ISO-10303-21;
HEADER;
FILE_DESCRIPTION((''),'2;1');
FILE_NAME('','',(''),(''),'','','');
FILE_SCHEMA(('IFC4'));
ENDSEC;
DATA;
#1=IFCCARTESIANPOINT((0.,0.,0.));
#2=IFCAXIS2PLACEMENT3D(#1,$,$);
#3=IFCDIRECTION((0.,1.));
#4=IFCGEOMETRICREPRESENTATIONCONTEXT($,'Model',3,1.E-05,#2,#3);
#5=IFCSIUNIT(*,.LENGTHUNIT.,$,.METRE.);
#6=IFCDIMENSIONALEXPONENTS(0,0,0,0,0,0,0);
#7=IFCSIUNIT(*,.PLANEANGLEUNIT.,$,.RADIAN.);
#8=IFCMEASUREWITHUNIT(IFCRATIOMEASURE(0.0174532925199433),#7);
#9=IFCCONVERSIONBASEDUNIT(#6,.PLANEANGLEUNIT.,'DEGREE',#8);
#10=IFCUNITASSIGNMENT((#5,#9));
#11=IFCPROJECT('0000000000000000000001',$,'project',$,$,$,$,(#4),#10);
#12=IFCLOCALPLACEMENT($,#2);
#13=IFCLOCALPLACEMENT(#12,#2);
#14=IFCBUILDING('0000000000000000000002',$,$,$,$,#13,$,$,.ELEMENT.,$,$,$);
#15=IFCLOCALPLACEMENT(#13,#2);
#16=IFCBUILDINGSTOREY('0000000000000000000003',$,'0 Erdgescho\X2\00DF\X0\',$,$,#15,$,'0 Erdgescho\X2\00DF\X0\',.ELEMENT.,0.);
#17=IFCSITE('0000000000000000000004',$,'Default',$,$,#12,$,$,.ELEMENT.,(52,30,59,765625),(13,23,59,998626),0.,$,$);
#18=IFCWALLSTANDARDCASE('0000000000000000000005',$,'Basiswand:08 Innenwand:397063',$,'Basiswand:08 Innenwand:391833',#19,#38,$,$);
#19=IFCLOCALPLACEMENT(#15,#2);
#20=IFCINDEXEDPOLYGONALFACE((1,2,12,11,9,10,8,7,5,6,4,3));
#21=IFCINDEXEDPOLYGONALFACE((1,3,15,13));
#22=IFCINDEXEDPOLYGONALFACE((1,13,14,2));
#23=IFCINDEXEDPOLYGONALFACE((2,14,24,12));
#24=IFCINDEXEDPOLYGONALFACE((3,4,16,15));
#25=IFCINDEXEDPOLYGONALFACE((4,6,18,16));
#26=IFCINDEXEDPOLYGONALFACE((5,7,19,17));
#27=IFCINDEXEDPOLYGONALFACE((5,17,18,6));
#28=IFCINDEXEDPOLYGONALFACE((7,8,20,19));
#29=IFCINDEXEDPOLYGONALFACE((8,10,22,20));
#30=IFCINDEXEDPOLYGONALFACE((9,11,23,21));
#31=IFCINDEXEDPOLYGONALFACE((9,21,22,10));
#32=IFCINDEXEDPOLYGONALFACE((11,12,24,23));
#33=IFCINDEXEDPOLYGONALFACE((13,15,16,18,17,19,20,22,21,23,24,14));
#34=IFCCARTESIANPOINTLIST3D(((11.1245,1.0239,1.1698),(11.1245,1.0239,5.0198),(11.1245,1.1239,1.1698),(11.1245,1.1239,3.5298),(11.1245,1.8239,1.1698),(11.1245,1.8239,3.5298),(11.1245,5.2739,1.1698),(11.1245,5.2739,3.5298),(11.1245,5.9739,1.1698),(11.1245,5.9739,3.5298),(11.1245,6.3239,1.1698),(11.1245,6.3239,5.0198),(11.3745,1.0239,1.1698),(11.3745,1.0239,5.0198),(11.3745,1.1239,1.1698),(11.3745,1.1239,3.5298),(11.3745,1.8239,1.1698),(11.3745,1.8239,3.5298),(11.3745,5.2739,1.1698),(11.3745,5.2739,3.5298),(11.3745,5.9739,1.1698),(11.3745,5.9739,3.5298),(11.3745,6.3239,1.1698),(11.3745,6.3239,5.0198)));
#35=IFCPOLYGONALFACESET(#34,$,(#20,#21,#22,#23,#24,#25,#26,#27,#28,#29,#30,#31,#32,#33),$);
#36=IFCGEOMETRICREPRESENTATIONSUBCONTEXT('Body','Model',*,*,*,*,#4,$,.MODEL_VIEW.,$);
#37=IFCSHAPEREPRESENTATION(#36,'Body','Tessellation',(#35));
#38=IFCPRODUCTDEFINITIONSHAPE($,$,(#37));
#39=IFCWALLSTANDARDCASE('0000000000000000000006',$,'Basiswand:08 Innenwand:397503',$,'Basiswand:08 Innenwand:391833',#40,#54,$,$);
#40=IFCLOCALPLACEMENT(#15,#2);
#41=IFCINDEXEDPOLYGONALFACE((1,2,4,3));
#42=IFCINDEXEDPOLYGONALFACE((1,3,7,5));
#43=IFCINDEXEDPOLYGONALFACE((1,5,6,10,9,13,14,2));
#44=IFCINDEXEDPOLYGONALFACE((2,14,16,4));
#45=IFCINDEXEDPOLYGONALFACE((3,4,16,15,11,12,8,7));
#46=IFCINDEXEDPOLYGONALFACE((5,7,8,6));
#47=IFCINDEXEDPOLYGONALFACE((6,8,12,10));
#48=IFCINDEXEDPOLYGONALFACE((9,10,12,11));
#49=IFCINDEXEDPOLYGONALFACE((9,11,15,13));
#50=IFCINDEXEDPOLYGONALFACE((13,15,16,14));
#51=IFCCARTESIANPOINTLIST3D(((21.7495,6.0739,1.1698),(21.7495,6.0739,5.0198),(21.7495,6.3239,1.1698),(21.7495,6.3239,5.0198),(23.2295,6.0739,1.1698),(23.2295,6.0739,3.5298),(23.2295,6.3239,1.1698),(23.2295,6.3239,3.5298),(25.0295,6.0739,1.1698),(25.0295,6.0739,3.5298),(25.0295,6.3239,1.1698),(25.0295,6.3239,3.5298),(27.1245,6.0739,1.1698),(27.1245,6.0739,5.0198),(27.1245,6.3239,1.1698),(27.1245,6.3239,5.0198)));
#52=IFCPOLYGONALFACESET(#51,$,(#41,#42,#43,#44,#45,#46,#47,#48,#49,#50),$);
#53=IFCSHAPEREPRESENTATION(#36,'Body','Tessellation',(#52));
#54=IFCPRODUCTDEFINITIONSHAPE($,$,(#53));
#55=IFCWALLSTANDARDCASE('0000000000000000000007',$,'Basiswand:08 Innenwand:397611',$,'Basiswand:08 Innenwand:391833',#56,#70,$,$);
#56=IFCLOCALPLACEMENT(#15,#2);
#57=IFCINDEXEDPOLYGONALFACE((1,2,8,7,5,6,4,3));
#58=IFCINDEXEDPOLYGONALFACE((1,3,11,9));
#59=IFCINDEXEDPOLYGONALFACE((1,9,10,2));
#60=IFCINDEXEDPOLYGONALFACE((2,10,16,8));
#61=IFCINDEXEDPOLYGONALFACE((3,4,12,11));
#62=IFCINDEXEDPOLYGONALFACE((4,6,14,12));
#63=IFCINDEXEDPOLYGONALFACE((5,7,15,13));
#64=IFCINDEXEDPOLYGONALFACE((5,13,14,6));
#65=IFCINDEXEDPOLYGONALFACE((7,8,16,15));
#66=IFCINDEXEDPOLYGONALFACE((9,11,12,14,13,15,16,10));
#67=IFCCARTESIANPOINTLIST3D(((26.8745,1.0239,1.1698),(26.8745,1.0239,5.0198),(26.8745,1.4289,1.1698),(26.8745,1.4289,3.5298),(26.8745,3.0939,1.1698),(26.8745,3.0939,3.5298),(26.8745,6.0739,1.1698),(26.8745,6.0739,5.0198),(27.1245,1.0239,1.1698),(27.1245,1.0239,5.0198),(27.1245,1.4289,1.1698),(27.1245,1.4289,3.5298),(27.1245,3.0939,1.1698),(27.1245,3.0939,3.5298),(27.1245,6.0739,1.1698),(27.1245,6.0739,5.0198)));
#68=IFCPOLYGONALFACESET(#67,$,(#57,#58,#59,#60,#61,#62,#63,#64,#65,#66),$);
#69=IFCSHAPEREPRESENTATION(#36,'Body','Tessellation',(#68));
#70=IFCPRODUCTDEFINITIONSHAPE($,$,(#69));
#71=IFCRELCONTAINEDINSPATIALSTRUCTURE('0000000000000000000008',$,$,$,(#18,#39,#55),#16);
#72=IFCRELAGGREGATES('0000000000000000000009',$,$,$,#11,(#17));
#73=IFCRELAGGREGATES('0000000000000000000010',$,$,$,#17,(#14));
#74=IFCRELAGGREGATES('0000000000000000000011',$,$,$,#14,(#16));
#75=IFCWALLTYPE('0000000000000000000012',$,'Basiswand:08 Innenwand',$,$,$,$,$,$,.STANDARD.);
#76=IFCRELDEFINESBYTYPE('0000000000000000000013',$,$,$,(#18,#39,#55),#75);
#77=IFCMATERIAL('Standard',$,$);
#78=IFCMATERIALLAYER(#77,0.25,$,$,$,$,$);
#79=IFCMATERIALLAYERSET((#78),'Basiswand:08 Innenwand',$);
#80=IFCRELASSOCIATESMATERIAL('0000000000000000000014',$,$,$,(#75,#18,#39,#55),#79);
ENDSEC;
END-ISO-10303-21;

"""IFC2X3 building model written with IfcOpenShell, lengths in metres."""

from ifc_helpers import new_model, entity, si_unit, converted_unit, direction, frame, frame_2d, origin, place, context, subcontext, project, spatial, polyline, rectangle, extrude, clip, bounded_halfspace, material, layer, layer_set, layer_usage, type_object, element, save


model = new_model("IFC2X3")

# Units and contexts
model_context = context("Model", 3, precision=1e-05, world=origin(), true_north=direction((0.0, 1.0)))
body_context = subcontext(model_context, "Body", "Model", "MODEL_VIEW")
ifc_project = project(units=[si_unit("LENGTHUNIT", "METRE"), converted_unit("PLANEANGLEUNIT", "DEGREE", entity("IfcRatioMeasure", 0.0174532925199433), si_unit("PLANEANGLEUNIT", "RADIAN"), dimensions=[0, 0, 0, 0, 0, 0, 0])], contexts=[model_context])

# Site, building, storey
site_placement = place(None, origin())
site = spatial("IfcSite", under=ifc_project, at=site_placement, Name="Default", CompositionType="ELEMENT", RefLatitude=(52, 30, 59, 765625), RefLongitude=(13, 23, 59, 998626), RefElevation=0.0)
building_placement = place(site_placement, origin())
building = spatial("IfcBuilding", under=site, at=building_placement, CompositionType="ELEMENT")
storey_placement = place(building_placement, origin())
storey = spatial("IfcBuildingStorey", under=building, at=storey_placement, Name="0 Erdgeschoß", LongName="0 Erdgeschoß", CompositionType="ELEMENT", Elevation=0.0)

# Wall, openings
ifc_material_1 = material(Name="Standard")
ifc_layer_1 = layer(ifc_material_1, 0.25)
ifc_layer_set_1 = layer_set([ifc_layer_1], Name="Basiswand:08 Innenwand")
ifc_layer_usage_1 = layer_usage(ifc_layer_set_1, "AXIS2", "NEGATIVE", 0.125)
wall_type_1 = type_object("IfcWallType", Name="Basiswand:08 Innenwand", PredefinedType="STANDARD", material=ifc_layer_set_1)
wall_1_placement = place(storey_placement, frame((11.2495, 1.0239, 1.1698), z_axis=(0.0, 0.0, 1.0), x_axis=(0.0, 1.0, 0.0)))
wall_1 = element("IfcWallStandardCase", 1, at=wall_1_placement, inside=storey, type_object=wall_type_1, material=ifc_layer_usage_1, Name="Basiswand:08 Innenwand:397063", ObjectType="Basiswand:08 Innenwand:391833", context=body_context, shape_type="Clipping", body=[
    clip(extrude(rectangle(XDim=5.3, YDim=0.25, at=frame_2d((2.65, 0.0), x_axis=(-1.0, 0.0))), origin(), (0.0, 0.0, 1.0), 3.85), bounded_halfspace(frame((0.0, -0.125, 3.85), z_axis=(0.0, 0.0, -1.0), x_axis=(-1.0, 0.0, 0.0)), True, frame((0.0, -0.125, 3.85)), polyline([(0.0, 0.0), (2.5, 0.0), (2.6, 0.0), (5.05, 0.0), (5.3, 0.0), (5.3, 0.15), (5.3, 0.25), (2.2, 0.25), (2.1, 0.25), (0.0, 0.25), (0.0, 0.0)]))),
])
opening_1_placement = place(wall_1_placement, frame((4.95, 0.125, 0.0)))
element("IfcOpeningElement", 2, at=opening_1_placement, cuts=wall_1, ObjectType="Opening", context=body_context, shape_type="SweptSolid", body=[
    extrude(rectangle(XDim=2.36, YDim=0.7, at=frame_2d((1.18, 0.35), x_axis=(1.0, 0.0))), frame((0.0, 0.0, 0.0), z_axis=(0.0, -1.0, 0.0), x_axis=(0.0, 0.0, 1.0)), (0.0, 0.0, 1.0), 0.25),
])
opening_2_placement = place(wall_1_placement, frame((0.8, 0.125, 0.0)))
element("IfcOpeningElement", 3, at=opening_2_placement, cuts=wall_1, ObjectType="Opening", context=body_context, shape_type="SweptSolid", body=[
    extrude(rectangle(XDim=2.36, YDim=0.7, at=frame_2d((1.18, 0.35), x_axis=(1.0, 0.0))), frame((0.0, 0.0, 0.0), z_axis=(0.0, -1.0, 0.0), x_axis=(0.0, 0.0, 1.0)), (0.0, 0.0, 1.0), 0.25),
])

# Walls, openings
ifc_layer_usage_2 = layer_usage(ifc_layer_set_1, "AXIS2", "NEGATIVE", 0.125)
wall_2_placement = place(storey_placement, frame((21.7495, 6.1989, 1.1698), z_axis=(0.0, 0.0, 1.0), x_axis=(1.0, 0.0, 0.0)))
wall_2 = element("IfcWallStandardCase", 4, at=wall_2_placement, inside=storey, type_object=wall_type_1, material=ifc_layer_usage_2, Name="Basiswand:08 Innenwand:397503", ObjectType="Basiswand:08 Innenwand:391833", context=body_context, shape_type="Clipping", body=[
    clip(extrude(rectangle(XDim=5.375, YDim=0.25, at=frame_2d((2.6875, 0.0), x_axis=(-1.0, 0.0))), origin(), (0.0, 0.0, 1.0), 3.85), bounded_halfspace(frame((0.0, -0.125, 3.85), z_axis=(0.0, 0.0, -1.0), x_axis=(0.0, -1.0, 0.0)), True, frame((0.0, -0.125, 3.85)), polyline([(0.0, 0.0), (5.125, 0.0), (5.375, 0.0), (5.375, 0.25), (0.0, 0.25), (0.0, 0.0)]))),
])
opening_3_placement = place(wall_2_placement, frame((3.28, 0.125, 0.0)))
element("IfcOpeningElement", 5, at=opening_3_placement, cuts=wall_2, ObjectType="Opening", context=body_context, shape_type="SweptSolid", body=[
    extrude(rectangle(XDim=2.36, YDim=1.8, at=frame_2d((1.18, 0.9), x_axis=(1.0, 0.0))), frame((0.0, 0.0, 0.0), z_axis=(0.0, -1.0, 0.0), x_axis=(0.0, 0.0, 1.0)), (0.0, 0.0, 1.0), 0.25),
])
ifc_layer_usage_3 = layer_usage(ifc_layer_set_1, "AXIS2", "NEGATIVE", 0.125)
wall_3_placement = place(storey_placement, frame((26.9995, 6.0739, 1.1698), z_axis=(0.0, 0.0, 1.0), x_axis=(0.0, -1.0, 0.0)))
wall_3 = element("IfcWallStandardCase", 6, at=wall_3_placement, inside=storey, type_object=wall_type_1, material=ifc_layer_usage_3, Name="Basiswand:08 Innenwand:397611", ObjectType="Basiswand:08 Innenwand:391833", context=body_context, shape_type="Clipping", body=[
    clip(extrude(rectangle(XDim=5.05, YDim=0.25, at=frame_2d((2.525, 0.0), x_axis=(-1.0, 0.0))), origin(), (0.0, 0.0, 1.0), 3.85), bounded_halfspace(frame((0.0, -0.125, 3.85), z_axis=(0.0, 0.0, -1.0), x_axis=(1.0, 0.0, 0.0)), True, frame((0.0, -0.125, 3.85)), polyline([(0.0, 0.0), (5.05, 0.0), (5.05, 0.25), (0.0, 0.25), (0.0, 0.0)]))),
])
opening_4_placement = place(wall_3_placement, frame((4.645, 0.125, 0.0)))
element("IfcOpeningElement", 7, at=opening_4_placement, cuts=wall_3, ObjectType="Opening", context=body_context, shape_type="SweptSolid", body=[
    extrude(rectangle(XDim=2.36, YDim=1.665, at=frame_2d((1.18, 0.8325), x_axis=(1.0, 0.0))), frame((0.0, 0.0, 0.0), z_axis=(0.0, -1.0, 0.0), x_axis=(0.0, 0.0, 1.0)), (0.0, 0.0, 1.0), 0.25),
])

save(model, "model.ifc")
